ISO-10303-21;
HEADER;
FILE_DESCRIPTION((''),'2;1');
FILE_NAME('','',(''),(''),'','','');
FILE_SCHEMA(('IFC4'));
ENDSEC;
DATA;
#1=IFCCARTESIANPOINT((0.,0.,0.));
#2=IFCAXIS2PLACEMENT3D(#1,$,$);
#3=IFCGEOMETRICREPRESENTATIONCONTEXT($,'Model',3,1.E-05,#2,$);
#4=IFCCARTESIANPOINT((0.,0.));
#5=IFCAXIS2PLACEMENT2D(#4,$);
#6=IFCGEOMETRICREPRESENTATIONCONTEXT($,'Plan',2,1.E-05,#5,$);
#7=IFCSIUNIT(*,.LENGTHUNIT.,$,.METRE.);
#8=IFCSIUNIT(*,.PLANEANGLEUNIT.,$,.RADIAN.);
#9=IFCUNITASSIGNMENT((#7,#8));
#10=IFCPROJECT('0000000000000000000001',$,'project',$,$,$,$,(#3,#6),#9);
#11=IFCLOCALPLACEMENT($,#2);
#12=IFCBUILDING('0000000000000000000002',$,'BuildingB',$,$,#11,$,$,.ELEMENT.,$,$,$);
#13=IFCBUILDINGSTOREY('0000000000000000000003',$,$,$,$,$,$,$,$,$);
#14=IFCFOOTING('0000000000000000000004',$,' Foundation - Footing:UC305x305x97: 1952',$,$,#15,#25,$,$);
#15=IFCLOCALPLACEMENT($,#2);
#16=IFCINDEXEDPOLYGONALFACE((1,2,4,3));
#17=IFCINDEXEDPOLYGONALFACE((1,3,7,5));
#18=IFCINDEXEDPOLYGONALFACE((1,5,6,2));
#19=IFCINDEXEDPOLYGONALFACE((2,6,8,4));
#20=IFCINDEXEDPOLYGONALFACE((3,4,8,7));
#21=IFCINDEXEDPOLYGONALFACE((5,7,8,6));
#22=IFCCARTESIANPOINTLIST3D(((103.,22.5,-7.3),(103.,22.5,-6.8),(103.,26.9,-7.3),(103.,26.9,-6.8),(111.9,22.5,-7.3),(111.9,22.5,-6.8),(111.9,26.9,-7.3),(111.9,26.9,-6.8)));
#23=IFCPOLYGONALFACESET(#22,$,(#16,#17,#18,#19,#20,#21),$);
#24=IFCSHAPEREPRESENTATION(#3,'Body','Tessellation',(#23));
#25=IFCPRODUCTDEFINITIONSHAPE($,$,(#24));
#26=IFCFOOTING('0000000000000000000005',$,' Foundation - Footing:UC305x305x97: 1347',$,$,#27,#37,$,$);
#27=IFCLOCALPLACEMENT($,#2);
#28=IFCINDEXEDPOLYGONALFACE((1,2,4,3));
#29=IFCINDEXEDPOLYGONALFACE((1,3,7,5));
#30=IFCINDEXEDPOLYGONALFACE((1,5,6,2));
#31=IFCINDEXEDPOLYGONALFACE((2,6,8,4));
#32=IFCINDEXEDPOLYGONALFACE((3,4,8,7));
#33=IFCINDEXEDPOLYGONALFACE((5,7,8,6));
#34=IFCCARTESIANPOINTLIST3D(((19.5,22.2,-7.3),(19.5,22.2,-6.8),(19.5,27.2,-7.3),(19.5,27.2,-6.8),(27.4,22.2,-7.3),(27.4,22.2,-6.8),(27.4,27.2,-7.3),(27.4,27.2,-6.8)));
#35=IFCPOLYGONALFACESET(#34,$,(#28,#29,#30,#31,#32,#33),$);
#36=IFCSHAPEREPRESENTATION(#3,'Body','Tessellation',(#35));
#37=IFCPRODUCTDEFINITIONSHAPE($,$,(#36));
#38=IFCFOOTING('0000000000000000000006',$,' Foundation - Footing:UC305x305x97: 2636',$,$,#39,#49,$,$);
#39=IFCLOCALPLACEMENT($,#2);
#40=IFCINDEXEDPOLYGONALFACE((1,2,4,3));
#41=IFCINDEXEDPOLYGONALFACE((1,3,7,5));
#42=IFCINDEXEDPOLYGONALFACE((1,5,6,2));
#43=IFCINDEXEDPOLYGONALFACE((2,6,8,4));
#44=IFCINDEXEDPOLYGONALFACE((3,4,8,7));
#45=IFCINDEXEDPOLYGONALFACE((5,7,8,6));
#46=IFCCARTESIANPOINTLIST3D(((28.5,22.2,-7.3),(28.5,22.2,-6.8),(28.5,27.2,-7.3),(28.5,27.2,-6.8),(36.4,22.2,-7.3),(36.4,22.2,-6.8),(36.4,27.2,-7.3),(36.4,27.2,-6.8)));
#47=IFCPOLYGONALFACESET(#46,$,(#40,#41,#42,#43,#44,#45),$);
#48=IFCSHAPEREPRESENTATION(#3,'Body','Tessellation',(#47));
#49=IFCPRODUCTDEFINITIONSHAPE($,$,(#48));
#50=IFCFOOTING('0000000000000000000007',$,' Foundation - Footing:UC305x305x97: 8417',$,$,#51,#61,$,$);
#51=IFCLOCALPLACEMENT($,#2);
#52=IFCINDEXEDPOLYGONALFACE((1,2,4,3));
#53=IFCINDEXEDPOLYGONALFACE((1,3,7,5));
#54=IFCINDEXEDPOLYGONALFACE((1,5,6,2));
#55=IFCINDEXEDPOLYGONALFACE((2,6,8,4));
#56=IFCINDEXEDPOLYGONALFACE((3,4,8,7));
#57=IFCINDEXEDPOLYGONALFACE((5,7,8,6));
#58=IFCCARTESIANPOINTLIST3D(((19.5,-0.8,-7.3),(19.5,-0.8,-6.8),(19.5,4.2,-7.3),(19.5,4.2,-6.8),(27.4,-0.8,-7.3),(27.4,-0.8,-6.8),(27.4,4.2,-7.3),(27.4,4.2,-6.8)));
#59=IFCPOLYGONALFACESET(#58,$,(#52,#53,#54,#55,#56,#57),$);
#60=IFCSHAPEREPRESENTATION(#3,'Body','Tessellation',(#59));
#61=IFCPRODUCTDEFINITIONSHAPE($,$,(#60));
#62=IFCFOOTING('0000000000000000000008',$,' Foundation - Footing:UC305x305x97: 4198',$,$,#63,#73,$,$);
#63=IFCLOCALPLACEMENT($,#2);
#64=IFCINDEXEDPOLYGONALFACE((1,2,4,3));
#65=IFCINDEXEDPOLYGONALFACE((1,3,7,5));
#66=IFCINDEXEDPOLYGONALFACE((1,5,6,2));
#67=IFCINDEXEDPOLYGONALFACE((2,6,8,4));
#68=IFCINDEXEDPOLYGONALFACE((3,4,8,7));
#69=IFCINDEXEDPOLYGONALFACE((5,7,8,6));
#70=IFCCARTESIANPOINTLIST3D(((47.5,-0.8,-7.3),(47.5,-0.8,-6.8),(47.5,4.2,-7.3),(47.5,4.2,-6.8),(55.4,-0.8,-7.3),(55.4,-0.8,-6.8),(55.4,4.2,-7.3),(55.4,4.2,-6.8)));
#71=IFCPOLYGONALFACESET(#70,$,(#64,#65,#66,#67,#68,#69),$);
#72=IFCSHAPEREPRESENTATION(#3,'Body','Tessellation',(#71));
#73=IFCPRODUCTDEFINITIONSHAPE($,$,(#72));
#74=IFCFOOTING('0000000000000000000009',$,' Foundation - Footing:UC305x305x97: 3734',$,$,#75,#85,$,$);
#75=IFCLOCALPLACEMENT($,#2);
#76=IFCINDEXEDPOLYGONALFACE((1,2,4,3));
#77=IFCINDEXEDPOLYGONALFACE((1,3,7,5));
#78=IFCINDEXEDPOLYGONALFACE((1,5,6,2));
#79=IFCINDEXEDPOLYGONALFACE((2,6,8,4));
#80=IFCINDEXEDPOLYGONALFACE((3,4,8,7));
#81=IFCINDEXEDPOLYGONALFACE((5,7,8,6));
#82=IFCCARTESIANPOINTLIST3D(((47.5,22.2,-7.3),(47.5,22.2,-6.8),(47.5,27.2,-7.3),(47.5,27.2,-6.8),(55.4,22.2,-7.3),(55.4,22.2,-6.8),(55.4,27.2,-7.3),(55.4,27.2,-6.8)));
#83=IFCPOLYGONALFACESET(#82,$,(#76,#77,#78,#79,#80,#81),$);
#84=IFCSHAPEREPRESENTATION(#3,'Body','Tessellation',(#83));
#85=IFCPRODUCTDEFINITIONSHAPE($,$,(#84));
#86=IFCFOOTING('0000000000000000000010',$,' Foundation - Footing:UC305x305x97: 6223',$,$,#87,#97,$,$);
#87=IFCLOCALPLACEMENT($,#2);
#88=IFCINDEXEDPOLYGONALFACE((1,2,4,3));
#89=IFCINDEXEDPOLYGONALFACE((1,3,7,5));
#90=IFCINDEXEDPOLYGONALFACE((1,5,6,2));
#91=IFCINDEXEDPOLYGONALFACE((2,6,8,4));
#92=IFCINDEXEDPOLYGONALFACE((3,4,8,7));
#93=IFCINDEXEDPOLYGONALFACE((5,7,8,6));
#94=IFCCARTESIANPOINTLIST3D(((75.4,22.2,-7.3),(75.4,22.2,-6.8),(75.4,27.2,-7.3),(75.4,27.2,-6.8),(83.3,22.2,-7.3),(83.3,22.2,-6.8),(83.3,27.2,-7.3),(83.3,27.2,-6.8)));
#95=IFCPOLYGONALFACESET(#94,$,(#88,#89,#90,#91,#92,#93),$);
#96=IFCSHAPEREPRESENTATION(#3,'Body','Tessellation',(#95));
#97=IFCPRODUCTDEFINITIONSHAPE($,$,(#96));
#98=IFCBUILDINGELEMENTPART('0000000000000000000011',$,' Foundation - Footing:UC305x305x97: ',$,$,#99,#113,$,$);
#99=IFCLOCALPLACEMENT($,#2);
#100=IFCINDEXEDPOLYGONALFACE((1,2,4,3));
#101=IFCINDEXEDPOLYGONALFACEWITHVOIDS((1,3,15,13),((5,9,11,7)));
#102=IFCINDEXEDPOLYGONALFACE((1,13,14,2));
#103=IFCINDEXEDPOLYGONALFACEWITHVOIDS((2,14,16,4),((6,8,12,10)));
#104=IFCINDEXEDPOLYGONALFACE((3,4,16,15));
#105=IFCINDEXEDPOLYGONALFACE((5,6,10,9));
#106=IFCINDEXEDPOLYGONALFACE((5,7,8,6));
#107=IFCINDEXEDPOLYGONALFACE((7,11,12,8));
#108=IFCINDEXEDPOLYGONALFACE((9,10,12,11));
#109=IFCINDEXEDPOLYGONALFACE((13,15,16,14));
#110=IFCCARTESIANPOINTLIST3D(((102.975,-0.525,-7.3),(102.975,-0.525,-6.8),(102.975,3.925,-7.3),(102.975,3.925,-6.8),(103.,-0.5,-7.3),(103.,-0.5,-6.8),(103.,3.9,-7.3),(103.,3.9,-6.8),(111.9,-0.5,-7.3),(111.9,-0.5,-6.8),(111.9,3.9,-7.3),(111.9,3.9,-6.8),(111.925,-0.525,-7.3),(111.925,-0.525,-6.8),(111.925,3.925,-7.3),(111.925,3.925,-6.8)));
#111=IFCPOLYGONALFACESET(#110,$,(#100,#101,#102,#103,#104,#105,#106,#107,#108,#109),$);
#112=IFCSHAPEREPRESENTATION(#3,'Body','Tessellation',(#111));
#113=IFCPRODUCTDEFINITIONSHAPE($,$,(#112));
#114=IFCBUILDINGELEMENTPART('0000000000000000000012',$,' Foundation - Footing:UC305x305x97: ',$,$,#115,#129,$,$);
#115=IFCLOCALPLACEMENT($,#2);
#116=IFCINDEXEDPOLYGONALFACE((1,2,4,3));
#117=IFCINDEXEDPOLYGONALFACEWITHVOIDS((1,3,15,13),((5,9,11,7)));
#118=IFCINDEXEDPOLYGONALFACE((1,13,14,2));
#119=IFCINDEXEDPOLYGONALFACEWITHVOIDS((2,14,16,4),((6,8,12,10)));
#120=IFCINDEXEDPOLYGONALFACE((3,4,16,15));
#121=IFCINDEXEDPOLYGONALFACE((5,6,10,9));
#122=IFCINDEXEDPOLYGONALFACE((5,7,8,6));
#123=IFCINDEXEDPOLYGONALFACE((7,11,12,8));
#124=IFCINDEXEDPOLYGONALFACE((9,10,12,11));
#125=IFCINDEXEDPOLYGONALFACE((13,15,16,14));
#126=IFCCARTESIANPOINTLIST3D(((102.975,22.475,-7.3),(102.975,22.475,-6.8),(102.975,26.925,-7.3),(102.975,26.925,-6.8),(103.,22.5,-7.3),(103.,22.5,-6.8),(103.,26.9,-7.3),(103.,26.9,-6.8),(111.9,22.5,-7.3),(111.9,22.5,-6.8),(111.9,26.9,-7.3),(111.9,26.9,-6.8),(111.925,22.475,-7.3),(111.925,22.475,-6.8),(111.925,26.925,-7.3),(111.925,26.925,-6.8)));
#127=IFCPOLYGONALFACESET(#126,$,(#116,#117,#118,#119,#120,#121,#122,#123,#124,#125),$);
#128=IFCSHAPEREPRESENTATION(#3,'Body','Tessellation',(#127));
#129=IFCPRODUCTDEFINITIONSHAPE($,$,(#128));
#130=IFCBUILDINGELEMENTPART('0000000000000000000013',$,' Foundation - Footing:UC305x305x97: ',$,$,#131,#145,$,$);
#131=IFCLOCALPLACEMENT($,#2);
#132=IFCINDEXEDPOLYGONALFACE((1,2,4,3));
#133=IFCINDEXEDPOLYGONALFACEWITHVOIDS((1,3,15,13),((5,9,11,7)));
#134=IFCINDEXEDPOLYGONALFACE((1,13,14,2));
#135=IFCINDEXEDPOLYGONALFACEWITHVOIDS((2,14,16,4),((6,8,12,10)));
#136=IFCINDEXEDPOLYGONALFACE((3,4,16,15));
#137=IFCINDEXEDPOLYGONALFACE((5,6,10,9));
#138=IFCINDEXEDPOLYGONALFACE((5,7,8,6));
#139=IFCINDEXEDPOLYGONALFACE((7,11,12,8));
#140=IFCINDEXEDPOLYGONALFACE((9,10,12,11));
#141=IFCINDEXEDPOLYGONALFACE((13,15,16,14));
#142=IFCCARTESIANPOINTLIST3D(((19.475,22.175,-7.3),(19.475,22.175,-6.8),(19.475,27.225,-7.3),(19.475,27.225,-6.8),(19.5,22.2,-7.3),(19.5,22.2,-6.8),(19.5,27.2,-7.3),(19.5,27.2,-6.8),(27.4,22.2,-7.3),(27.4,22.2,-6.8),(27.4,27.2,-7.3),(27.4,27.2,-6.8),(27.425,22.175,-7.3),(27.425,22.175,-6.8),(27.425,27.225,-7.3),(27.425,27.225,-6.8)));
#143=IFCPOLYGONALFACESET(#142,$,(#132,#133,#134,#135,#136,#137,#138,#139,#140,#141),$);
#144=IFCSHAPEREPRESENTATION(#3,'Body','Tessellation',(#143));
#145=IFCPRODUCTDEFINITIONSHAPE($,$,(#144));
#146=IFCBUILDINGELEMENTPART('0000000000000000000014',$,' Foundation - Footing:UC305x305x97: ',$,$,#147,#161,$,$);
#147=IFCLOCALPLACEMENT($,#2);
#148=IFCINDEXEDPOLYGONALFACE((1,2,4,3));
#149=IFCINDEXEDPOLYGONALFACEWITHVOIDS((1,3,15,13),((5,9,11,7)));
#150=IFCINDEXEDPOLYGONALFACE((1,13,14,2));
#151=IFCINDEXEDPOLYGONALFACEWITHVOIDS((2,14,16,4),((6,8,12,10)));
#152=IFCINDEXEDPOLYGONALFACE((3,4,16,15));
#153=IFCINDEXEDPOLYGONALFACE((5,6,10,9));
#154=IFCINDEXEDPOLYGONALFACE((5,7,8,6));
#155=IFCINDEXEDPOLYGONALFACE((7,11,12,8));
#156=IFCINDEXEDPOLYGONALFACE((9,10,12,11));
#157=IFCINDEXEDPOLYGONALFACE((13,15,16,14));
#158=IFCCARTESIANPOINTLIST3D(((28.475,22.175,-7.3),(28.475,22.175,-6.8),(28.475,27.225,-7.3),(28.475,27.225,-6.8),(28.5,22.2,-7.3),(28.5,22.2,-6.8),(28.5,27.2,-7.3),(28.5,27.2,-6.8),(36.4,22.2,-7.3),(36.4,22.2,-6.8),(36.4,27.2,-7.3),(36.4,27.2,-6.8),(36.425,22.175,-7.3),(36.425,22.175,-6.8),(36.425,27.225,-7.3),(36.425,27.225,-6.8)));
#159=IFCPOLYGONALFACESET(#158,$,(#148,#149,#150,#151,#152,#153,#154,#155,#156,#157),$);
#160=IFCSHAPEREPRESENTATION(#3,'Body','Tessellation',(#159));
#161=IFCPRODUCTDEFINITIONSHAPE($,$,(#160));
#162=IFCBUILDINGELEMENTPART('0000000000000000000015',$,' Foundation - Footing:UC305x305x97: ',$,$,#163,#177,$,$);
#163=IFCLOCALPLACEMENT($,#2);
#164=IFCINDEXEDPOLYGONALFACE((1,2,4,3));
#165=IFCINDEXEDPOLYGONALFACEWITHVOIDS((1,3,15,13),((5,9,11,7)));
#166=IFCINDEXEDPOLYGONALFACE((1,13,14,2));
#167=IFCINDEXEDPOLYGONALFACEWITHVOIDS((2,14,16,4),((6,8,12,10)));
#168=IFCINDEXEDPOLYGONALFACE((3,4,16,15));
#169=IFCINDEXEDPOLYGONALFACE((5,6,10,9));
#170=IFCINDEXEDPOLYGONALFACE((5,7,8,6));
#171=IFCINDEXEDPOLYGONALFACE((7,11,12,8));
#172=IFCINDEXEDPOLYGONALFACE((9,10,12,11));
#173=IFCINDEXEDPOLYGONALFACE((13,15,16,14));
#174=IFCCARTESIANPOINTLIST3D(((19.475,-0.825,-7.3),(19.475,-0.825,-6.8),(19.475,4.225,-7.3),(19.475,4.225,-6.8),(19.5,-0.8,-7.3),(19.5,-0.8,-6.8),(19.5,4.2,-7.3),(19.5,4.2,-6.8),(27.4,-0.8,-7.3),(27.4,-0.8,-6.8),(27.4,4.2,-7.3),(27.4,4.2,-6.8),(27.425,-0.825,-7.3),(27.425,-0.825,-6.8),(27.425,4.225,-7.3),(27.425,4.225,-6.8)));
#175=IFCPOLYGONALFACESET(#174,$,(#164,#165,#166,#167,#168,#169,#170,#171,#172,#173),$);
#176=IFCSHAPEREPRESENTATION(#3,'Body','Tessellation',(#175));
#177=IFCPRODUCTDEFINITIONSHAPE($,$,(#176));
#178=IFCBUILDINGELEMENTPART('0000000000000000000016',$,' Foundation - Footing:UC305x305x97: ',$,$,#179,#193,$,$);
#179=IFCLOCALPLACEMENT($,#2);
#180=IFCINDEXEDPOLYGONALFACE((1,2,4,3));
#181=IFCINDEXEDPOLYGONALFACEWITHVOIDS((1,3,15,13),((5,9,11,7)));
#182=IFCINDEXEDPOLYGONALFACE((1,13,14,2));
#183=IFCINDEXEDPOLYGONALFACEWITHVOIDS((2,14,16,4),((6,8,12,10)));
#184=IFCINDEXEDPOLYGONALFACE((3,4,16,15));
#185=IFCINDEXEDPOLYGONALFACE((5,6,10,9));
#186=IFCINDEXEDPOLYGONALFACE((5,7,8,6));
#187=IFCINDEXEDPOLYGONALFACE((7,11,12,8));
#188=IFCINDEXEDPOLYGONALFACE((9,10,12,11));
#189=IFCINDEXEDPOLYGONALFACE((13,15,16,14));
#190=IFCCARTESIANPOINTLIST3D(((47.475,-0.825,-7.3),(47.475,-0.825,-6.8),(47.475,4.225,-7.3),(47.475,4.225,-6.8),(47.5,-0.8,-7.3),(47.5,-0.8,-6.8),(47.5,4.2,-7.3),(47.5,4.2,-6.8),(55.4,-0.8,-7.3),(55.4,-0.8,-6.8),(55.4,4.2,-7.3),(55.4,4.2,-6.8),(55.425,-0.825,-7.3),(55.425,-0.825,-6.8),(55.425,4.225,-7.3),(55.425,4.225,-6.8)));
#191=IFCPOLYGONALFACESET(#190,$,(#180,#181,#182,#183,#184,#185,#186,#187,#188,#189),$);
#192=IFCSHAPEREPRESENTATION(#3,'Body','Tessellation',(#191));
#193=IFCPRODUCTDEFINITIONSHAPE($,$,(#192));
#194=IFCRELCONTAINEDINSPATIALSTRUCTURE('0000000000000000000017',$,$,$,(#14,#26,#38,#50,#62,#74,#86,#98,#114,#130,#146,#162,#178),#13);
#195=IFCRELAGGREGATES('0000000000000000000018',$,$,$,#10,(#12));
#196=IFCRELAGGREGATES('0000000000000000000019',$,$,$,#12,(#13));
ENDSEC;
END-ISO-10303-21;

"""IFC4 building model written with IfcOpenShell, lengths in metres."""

from ifc_helpers import new_model, si_unit, origin, origin_2d, place, context, project, spatial, polyline, outline, extrude, element, save


model = new_model("IFC4")

# Units and contexts
model_context = context("Model", 3, precision=1e-05, world=origin())
plan_context = context("Plan", 2, precision=1e-05, world=origin_2d())
ifc_project = project(units=[si_unit("LENGTHUNIT", "METRE"), si_unit("PLANEANGLEUNIT", "RADIAN")], contexts=[model_context, plan_context])

# Building, storey
building_placement = place(None, origin())
building = spatial("IfcBuilding", under=ifc_project, at=building_placement, Name="BuildingB", CompositionType="ELEMENT")
storey = spatial("IfcBuildingStorey", under=building)

# Footings
element("IfcFooting", 1, inside=storey, Name=" Foundation - Footing:UC305x305x97: 1952", context=model_context, shape_type="SweptSolid", body=[
    extrude(outline(polyline([(111.9, 26.9, -7.3), (103.0, 26.9, -7.3), (103.0, 22.5, -7.3), (111.9, 22.5, -7.3), (111.9, 26.9, -7.3)])), None, (0.0, 0.0, 1.0), 0.5),
])
element("IfcFooting", 2, inside=storey, Name=" Foundation - Footing:UC305x305x97: 1347", context=model_context, shape_type="SweptSolid", body=[
    extrude(outline(polyline([(27.4, 27.2, -7.3), (19.5, 27.2, -7.3), (19.5, 22.2, -7.3), (27.4, 22.2, -7.3), (27.4, 27.2, -7.3)])), None, (0.0, 0.0, 1.0), 0.5),
])
element("IfcFooting", 3, inside=storey, Name=" Foundation - Footing:UC305x305x97: 2636", context=model_context, shape_type="SweptSolid", body=[
    extrude(outline(polyline([(36.4, 27.2, -7.3), (28.5, 27.2, -7.3), (28.5, 22.2, -7.3), (36.4, 22.2, -7.3), (36.4, 27.2, -7.3)])), None, (0.0, 0.0, 1.0), 0.5),
])
element("IfcFooting", 4, inside=storey, Name=" Foundation - Footing:UC305x305x97: 8417", context=model_context, shape_type="SweptSolid", body=[
    extrude(outline(polyline([(27.4, 4.2, -7.3), (19.5, 4.2, -7.3), (19.5, -0.8, -7.3), (27.4, -0.8, -7.3), (27.4, 4.2, -7.3)])), None, (0.0, 0.0, 1.0), 0.5),
])
element("IfcFooting", 5, inside=storey, Name=" Foundation - Footing:UC305x305x97: 4198", context=model_context, shape_type="SweptSolid", body=[
    extrude(outline(polyline([(55.4, 4.2, -7.3), (47.5, 4.2, -7.3), (47.5, -0.8, -7.3), (55.4, -0.8, -7.3), (55.4, 4.2, -7.3)])), None, (0.0, 0.0, 1.0), 0.5),
])
element("IfcFooting", 6, inside=storey, Name=" Foundation - Footing:UC305x305x97: 3734", context=model_context, shape_type="SweptSolid", body=[
    extrude(outline(polyline([(55.4, 27.2, -7.3), (47.5, 27.2, -7.3), (47.5, 22.2, -7.3), (55.4, 22.2, -7.3), (55.4, 27.2, -7.3)])), None, (0.0, 0.0, 1.0), 0.5),
])
element("IfcFooting", 7, inside=storey, Name=" Foundation - Footing:UC305x305x97: 6223", context=model_context, shape_type="SweptSolid", body=[
    extrude(outline(polyline([(83.3, 27.2, -7.3), (75.4, 27.2, -7.3), (75.4, 22.2, -7.3), (83.3, 22.2, -7.3), (83.3, 27.2, -7.3)])), None, (0.0, 0.0, 1.0), 0.5),
])

# Building element parts, openings
building_element_part_1 = element("IfcBuildingElementPart", 8, inside=storey, Name=" Foundation - Footing:UC305x305x97: ", context=model_context, shape_type="SweptSolid", body=[
    extrude(outline(polyline([(111.925, 3.925, -7.3), (102.975, 3.925, -7.3), (102.975, -0.525, -7.3), (111.925, -0.525, -7.3), (111.925, 3.925, -7.3)])), None, (0.0, 0.0, 1.0), 0.5),
])
element("IfcOpeningElement", 9, inside=storey, cuts=building_element_part_1, context=model_context, shape_type="SweptSolid", body=[
    extrude(outline(polyline([(111.9, 3.9, -7.3), (103.0, 3.9, -7.3), (103.0, -0.5, -7.3), (111.9, -0.5, -7.3), (111.9, 3.9, -7.3)])), None, (0.0, 0.0, 1.0), 0.5),
])
building_element_part_2 = element("IfcBuildingElementPart", 10, inside=storey, Name=" Foundation - Footing:UC305x305x97: ", context=model_context, shape_type="SweptSolid", body=[
    extrude(outline(polyline([(111.925, 26.925, -7.3), (102.975, 26.925, -7.3), (102.975, 22.475, -7.3), (111.925, 22.475, -7.3), (111.925, 26.925, -7.3)])), None, (0.0, 0.0, 1.0), 0.5),
])
element("IfcOpeningElement", 11, inside=storey, cuts=building_element_part_2, context=model_context, shape_type="SweptSolid", body=[
    extrude(outline(polyline([(111.9, 26.9, -7.3), (103.0, 26.9, -7.3), (103.0, 22.5, -7.3), (111.9, 22.5, -7.3), (111.9, 26.9, -7.3)])), None, (0.0, 0.0, 1.0), 0.5),
])
building_element_part_3 = element("IfcBuildingElementPart", 12, inside=storey, Name=" Foundation - Footing:UC305x305x97: ", context=model_context, shape_type="SweptSolid", body=[
    extrude(outline(polyline([(27.425, 27.225, -7.3), (19.475, 27.225, -7.3), (19.475, 22.175, -7.3), (27.425, 22.175, -7.3), (27.425, 27.225, -7.3)])), None, (0.0, 0.0, 1.0), 0.5),
])
element("IfcOpeningElement", 13, inside=storey, cuts=building_element_part_3, context=model_context, shape_type="SweptSolid", body=[
    extrude(outline(polyline([(27.4, 27.2, -7.3), (19.5, 27.2, -7.3), (19.5, 22.2, -7.3), (27.4, 22.2, -7.3), (27.4, 27.2, -7.3)])), None, (0.0, 0.0, 1.0), 0.5),
])
building_element_part_4 = element("IfcBuildingElementPart", 14, inside=storey, Name=" Foundation - Footing:UC305x305x97: ", context=model_context, shape_type="SweptSolid", body=[
    extrude(outline(polyline([(36.425, 27.225, -7.3), (28.475, 27.225, -7.3), (28.475, 22.175, -7.3), (36.425, 22.175, -7.3), (36.425, 27.225, -7.3)])), None, (0.0, 0.0, 1.0), 0.5),
])
element("IfcOpeningElement", 15, inside=storey, cuts=building_element_part_4, context=model_context, shape_type="SweptSolid", body=[
    extrude(outline(polyline([(36.4, 27.2, -7.3), (28.5, 27.2, -7.3), (28.5, 22.2, -7.3), (36.4, 22.2, -7.3), (36.4, 27.2, -7.3)])), None, (0.0, 0.0, 1.0), 0.5),
])
building_element_part_5 = element("IfcBuildingElementPart", 16, inside=storey, Name=" Foundation - Footing:UC305x305x97: ", context=model_context, shape_type="SweptSolid", body=[
    extrude(outline(polyline([(27.425, 4.225, -7.3), (19.475, 4.225, -7.3), (19.475, -0.825, -7.3), (27.425, -0.825, -7.3), (27.425, 4.225, -7.3)])), None, (0.0, 0.0, 1.0), 0.5),
])
element("IfcOpeningElement", 17, inside=storey, cuts=building_element_part_5, context=model_context, shape_type="SweptSolid", body=[
    extrude(outline(polyline([(27.4, 4.2, -7.3), (19.5, 4.2, -7.3), (19.5, -0.8, -7.3), (27.4, -0.8, -7.3), (27.4, 4.2, -7.3)])), None, (0.0, 0.0, 1.0), 0.5),
])
building_element_part_6 = element("IfcBuildingElementPart", 18, inside=storey, Name=" Foundation - Footing:UC305x305x97: ", context=model_context, shape_type="SweptSolid", body=[
    extrude(outline(polyline([(55.425, 4.225, -7.3), (47.475, 4.225, -7.3), (47.475, -0.825, -7.3), (55.425, -0.825, -7.3), (55.425, 4.225, -7.3)])), None, (0.0, 0.0, 1.0), 0.5),
])
element("IfcOpeningElement", 19, inside=storey, cuts=building_element_part_6, context=model_context, shape_type="SweptSolid", body=[
    extrude(outline(polyline([(55.4, 4.2, -7.3), (47.5, 4.2, -7.3), (47.5, -0.8, -7.3), (55.4, -0.8, -7.3), (55.4, 4.2, -7.3)])), None, (0.0, 0.0, 1.0), 0.5),
])

save(model, "model.ifc")
